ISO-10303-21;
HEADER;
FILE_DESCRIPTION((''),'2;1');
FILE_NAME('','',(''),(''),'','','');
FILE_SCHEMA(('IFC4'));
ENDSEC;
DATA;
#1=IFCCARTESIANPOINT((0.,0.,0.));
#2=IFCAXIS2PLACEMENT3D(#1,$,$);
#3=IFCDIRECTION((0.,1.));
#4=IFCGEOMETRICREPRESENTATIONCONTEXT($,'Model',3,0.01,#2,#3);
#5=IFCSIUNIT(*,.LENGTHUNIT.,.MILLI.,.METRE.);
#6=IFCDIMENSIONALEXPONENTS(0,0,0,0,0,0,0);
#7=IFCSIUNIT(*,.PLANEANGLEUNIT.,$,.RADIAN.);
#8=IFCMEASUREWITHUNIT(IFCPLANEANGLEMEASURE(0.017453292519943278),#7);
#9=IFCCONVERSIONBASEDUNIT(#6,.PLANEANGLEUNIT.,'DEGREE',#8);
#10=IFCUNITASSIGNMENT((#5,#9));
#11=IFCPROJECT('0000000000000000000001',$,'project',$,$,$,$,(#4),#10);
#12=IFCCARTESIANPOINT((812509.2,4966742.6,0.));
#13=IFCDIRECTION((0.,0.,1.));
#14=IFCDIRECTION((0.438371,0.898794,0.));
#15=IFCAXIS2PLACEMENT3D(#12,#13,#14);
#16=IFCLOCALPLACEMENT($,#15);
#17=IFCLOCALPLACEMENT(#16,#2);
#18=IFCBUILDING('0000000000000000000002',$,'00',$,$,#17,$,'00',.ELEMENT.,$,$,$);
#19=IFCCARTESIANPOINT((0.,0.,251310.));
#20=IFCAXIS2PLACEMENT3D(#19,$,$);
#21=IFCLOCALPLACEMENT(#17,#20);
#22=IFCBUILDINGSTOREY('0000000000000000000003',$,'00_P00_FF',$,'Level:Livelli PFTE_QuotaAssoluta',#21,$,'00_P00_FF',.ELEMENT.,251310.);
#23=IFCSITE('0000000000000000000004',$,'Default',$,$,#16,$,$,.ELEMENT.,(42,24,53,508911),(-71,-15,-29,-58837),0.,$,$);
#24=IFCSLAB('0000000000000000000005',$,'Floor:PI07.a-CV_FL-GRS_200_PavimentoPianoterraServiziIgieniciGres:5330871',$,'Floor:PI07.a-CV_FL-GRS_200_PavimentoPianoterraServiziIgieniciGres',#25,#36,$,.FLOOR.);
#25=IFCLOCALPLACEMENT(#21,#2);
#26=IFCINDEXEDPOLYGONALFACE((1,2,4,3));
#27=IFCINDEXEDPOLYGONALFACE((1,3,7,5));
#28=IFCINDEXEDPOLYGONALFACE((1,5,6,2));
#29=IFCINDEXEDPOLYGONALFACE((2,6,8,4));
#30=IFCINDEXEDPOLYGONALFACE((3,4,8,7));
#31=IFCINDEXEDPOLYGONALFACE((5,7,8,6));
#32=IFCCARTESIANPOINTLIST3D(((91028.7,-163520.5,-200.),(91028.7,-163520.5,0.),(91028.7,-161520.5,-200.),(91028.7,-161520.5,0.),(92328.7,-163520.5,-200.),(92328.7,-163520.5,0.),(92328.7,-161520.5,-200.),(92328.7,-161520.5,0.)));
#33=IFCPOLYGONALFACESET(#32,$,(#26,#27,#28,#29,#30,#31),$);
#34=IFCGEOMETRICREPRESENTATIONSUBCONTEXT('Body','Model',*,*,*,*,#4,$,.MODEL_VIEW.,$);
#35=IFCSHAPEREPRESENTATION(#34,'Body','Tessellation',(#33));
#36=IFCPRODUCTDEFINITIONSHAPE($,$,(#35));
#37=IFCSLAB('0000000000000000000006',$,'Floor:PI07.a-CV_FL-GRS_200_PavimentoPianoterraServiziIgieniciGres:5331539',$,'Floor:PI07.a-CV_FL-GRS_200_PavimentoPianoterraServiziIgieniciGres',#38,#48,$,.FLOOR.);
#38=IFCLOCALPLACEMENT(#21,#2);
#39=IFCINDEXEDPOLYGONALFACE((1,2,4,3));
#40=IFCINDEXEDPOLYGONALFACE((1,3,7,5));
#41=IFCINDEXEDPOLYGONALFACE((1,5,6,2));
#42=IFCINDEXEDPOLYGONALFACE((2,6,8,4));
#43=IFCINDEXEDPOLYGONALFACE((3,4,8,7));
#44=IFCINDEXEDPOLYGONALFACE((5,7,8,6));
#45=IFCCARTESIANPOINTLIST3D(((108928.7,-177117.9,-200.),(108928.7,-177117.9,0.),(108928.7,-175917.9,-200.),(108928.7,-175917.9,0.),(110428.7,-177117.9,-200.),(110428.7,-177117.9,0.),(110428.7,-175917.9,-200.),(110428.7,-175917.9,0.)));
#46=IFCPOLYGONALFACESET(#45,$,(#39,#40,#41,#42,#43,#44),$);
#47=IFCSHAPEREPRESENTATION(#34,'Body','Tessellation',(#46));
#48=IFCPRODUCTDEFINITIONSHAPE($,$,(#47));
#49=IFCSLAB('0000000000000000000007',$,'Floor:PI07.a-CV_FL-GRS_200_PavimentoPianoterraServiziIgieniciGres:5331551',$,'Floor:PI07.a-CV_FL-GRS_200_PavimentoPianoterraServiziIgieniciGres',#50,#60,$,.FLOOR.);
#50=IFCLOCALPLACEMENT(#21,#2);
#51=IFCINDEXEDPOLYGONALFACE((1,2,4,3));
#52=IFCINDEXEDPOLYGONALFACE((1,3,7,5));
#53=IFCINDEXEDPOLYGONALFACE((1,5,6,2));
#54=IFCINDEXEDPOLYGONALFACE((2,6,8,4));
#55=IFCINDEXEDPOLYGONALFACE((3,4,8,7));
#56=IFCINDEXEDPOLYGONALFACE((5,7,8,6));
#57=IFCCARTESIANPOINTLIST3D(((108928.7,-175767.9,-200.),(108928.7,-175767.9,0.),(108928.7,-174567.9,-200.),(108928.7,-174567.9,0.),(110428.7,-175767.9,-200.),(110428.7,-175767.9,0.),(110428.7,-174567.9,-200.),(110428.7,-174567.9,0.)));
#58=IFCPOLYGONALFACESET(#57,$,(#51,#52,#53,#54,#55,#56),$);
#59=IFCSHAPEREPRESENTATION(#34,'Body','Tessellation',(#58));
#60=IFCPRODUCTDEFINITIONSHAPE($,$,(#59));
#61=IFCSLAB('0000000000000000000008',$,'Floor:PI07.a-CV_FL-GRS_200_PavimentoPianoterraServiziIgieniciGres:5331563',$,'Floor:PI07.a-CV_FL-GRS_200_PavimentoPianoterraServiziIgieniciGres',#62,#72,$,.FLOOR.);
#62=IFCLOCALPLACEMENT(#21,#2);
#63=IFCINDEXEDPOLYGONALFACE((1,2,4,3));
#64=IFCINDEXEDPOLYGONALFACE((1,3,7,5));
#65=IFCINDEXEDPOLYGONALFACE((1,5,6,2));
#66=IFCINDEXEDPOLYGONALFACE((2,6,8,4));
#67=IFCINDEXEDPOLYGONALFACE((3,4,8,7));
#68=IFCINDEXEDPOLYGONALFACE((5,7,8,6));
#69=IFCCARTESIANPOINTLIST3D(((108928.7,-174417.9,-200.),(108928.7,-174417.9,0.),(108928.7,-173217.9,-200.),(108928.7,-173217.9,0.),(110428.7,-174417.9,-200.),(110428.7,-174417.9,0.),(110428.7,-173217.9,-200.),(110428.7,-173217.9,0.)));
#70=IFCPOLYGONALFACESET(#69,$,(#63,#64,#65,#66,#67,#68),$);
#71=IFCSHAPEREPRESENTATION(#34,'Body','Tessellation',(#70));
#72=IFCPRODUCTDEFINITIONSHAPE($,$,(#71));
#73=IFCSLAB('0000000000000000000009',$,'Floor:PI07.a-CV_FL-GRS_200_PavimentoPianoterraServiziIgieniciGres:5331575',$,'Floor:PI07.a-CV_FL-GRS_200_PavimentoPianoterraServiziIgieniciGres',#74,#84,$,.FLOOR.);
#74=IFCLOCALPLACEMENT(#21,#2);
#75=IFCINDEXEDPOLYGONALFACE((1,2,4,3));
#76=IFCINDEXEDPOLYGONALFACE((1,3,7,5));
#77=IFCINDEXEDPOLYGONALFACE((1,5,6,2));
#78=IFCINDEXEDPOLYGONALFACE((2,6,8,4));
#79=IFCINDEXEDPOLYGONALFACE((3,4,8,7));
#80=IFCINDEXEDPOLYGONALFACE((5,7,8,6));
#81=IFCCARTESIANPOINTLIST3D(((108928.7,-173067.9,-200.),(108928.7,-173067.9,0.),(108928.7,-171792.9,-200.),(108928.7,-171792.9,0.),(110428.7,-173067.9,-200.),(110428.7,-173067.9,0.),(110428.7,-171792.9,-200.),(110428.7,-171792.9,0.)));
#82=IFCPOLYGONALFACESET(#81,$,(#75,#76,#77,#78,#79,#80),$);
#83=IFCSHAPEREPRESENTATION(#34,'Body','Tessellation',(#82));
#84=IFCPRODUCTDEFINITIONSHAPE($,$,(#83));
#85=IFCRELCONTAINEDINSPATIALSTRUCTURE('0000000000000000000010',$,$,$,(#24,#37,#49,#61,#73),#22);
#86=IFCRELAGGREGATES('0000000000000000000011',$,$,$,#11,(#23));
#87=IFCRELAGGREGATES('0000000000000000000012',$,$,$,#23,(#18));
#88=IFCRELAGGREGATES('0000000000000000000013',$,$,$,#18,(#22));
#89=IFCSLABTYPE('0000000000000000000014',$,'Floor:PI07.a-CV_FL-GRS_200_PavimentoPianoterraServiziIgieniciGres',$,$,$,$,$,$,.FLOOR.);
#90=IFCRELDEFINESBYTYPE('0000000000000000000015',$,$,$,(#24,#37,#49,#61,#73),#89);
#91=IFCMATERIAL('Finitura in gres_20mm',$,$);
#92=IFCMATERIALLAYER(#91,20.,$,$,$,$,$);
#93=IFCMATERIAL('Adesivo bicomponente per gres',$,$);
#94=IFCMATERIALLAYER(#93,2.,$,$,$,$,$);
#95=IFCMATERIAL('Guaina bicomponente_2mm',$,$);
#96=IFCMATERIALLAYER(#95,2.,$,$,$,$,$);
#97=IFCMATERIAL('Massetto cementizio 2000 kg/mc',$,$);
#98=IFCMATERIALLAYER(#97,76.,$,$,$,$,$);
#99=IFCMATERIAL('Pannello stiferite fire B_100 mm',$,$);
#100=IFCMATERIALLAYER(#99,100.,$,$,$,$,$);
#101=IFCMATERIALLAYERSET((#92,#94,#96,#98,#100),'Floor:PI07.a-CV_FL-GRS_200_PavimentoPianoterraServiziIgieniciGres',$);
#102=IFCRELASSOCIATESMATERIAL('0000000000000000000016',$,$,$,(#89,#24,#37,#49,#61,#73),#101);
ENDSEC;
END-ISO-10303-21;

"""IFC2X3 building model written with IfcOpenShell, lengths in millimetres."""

from ifc_helpers import new_model, entity, si_unit, converted_unit, direction, frame, frame_2d, origin, origin_2d_with_axis, place, context, subcontext, project, spatial, rectangle, extrude, material, layer, layer_set, layer_usage, type_object, element, save


model = new_model("IFC2X3")

# Units and contexts
model_context = context("Model", 3, precision=0.01, world=origin(), true_north=direction((0.0, 1.0)))
body_context = subcontext(model_context, "Body", "Model", "MODEL_VIEW")
ifc_project = project(units=[si_unit("LENGTHUNIT", "METRE", prefix="MILLI"), converted_unit("PLANEANGLEUNIT", "DEGREE", entity("IfcPlaneAngleMeasure", 0.017453292519943278), si_unit("PLANEANGLEUNIT", "RADIAN"), dimensions=[0, 0, 0, 0, 0, 0, 0])], contexts=[model_context])

# Site, building, storey
site_placement = place(None, frame((812509.2, 4966742.6, 0.0), z_axis=(0.0, 0.0, 1.0), x_axis=(0.438371, 0.898794, 0.0)))
site = spatial("IfcSite", under=ifc_project, at=site_placement, Name="Default", CompositionType="ELEMENT", RefLatitude=(42, 24, 53, 508911), RefLongitude=(-71, -15, -29, -58837), RefElevation=0.0)
building_placement = place(site_placement, origin())
building = spatial("IfcBuilding", under=site, at=building_placement, Name="00", LongName="00", CompositionType="ELEMENT")
storey_placement = place(building_placement, frame((0.0, 0.0, 251310.0)))
storey = spatial("IfcBuildingStorey", under=building, at=storey_placement, Name="00_P00_FF", ObjectType="Level:Livelli PFTE_QuotaAssoluta", LongName="00_P00_FF", CompositionType="ELEMENT", Elevation=251310.0)

# Shared definitions
ifc_material_1 = material(Name="Massetto cementizio 2000 kg/mc")
ifc_material_2 = material(Name="Pannello stiferite fire B_100 mm")

# Slabs
ifc_material_3 = material(Name="Finitura in gres_20mm")
ifc_layer_1 = layer(ifc_material_3, 20.0)
ifc_material_4 = material(Name="Adesivo bicomponente per gres")
ifc_layer_2 = layer(ifc_material_4, 2.0)
ifc_material_5 = material(Name="Guaina bicomponente_2mm")
ifc_layer_3 = layer(ifc_material_5, 2.0)
ifc_layer_4 = layer(ifc_material_1, 76.0)
ifc_layer_5 = layer(ifc_material_2, 100.0)
ifc_layer_set_1 = layer_set([ifc_layer_1, ifc_layer_2, ifc_layer_3, ifc_layer_4, ifc_layer_5], Name="Floor:PI07.a-CV_FL-GRS_200_PavimentoPianoterraServiziIgieniciGres")
ifc_layer_usage_1 = layer_usage(ifc_layer_set_1, "AXIS3", "POSITIVE", 0.0)
slab_type_1 = type_object("IfcSlabType", Name="Floor:PI07.a-CV_FL-GRS_200_PavimentoPianoterraServiziIgieniciGres", PredefinedType="FLOOR", material=ifc_layer_set_1)
slab_1_placement = place(storey_placement, origin())
element("IfcSlab", 1, at=slab_1_placement, inside=storey, type_object=slab_type_1, material=ifc_layer_usage_1, Name="Floor:PI07.a-CV_FL-GRS_200_PavimentoPianoterraServiziIgieniciGres:5330871", ObjectType="Floor:PI07.a-CV_FL-GRS_200_PavimentoPianoterraServiziIgieniciGres", PredefinedType="FLOOR", context=body_context, shape_type="SweptSolid", body=[
    extrude(rectangle(XDim=2000.0, YDim=1300.0, at=frame_2d((0.0, 0.0), x_axis=(1.0, 0.0))), frame((91678.7, -162520.5, 0.0), z_axis=(0.0, 0.0, -1.0), x_axis=(0.0, 1.0, 0.0)), (0.0, 0.0, 1.0), 200.0),
])
ifc_layer_usage_2 = layer_usage(ifc_layer_set_1, "AXIS3", "POSITIVE", 0.0)
slab_2_placement = place(storey_placement, origin())
element("IfcSlab", 2, at=slab_2_placement, inside=storey, type_object=slab_type_1, material=ifc_layer_usage_2, Name="Floor:PI07.a-CV_FL-GRS_200_PavimentoPianoterraServiziIgieniciGres:5331539", ObjectType="Floor:PI07.a-CV_FL-GRS_200_PavimentoPianoterraServiziIgieniciGres", PredefinedType="FLOOR", context=body_context, shape_type="SweptSolid", body=[
    extrude(rectangle(XDim=1200.0, YDim=1500.0, at=origin_2d_with_axis()), frame((109678.7, -176517.9, 0.0), z_axis=(0.0, 0.0, -1.0), x_axis=(0.0, 1.0, 0.0)), (0.0, 0.0, 1.0), 200.0),
])
ifc_layer_usage_3 = layer_usage(ifc_layer_set_1, "AXIS3", "POSITIVE", 0.0)
slab_3_placement = place(storey_placement, origin())
element("IfcSlab", 3, at=slab_3_placement, inside=storey, type_object=slab_type_1, material=ifc_layer_usage_3, Name="Floor:PI07.a-CV_FL-GRS_200_PavimentoPianoterraServiziIgieniciGres:5331551", ObjectType="Floor:PI07.a-CV_FL-GRS_200_PavimentoPianoterraServiziIgieniciGres", PredefinedType="FLOOR", context=body_context, shape_type="SweptSolid", body=[
    extrude(rectangle(XDim=1200.0, YDim=1500.0, at=origin_2d_with_axis()), frame((109678.7, -175167.9, 0.0), z_axis=(0.0, 0.0, -1.0), x_axis=(0.0, 1.0, 0.0)), (0.0, 0.0, 1.0), 200.0),
])
ifc_layer_usage_4 = layer_usage(ifc_layer_set_1, "AXIS3", "POSITIVE", 0.0)
slab_4_placement = place(storey_placement, origin())
element("IfcSlab", 4, at=slab_4_placement, inside=storey, type_object=slab_type_1, material=ifc_layer_usage_4, Name="Floor:PI07.a-CV_FL-GRS_200_PavimentoPianoterraServiziIgieniciGres:5331563", ObjectType="Floor:PI07.a-CV_FL-GRS_200_PavimentoPianoterraServiziIgieniciGres", PredefinedType="FLOOR", context=body_context, shape_type="SweptSolid", body=[
    extrude(rectangle(XDim=1200.0, YDim=1500.0, at=frame_2d((0.0, 0.0), x_axis=(1.0, 0.0))), frame((109678.7, -173817.9, 0.0), z_axis=(0.0, 0.0, -1.0), x_axis=(0.0, 1.0, 0.0)), (0.0, 0.0, 1.0), 200.0),
])
ifc_layer_usage_5 = layer_usage(ifc_layer_set_1, "AXIS3", "POSITIVE", 0.0)
slab_5_placement = place(storey_placement, origin())
element("IfcSlab", 5, at=slab_5_placement, inside=storey, type_object=slab_type_1, material=ifc_layer_usage_5, Name="Floor:PI07.a-CV_FL-GRS_200_PavimentoPianoterraServiziIgieniciGres:5331575", ObjectType="Floor:PI07.a-CV_FL-GRS_200_PavimentoPianoterraServiziIgieniciGres", PredefinedType="FLOOR", context=body_context, shape_type="SweptSolid", body=[
    extrude(rectangle(XDim=1275.0, YDim=1500.0, at=origin_2d_with_axis()), frame((109678.7, -172430.4, 0.0), z_axis=(0.0, 0.0, -1.0), x_axis=(0.0, 1.0, 0.0)), (0.0, 0.0, 1.0), 200.0),
])

save(model, "model.ifc")
